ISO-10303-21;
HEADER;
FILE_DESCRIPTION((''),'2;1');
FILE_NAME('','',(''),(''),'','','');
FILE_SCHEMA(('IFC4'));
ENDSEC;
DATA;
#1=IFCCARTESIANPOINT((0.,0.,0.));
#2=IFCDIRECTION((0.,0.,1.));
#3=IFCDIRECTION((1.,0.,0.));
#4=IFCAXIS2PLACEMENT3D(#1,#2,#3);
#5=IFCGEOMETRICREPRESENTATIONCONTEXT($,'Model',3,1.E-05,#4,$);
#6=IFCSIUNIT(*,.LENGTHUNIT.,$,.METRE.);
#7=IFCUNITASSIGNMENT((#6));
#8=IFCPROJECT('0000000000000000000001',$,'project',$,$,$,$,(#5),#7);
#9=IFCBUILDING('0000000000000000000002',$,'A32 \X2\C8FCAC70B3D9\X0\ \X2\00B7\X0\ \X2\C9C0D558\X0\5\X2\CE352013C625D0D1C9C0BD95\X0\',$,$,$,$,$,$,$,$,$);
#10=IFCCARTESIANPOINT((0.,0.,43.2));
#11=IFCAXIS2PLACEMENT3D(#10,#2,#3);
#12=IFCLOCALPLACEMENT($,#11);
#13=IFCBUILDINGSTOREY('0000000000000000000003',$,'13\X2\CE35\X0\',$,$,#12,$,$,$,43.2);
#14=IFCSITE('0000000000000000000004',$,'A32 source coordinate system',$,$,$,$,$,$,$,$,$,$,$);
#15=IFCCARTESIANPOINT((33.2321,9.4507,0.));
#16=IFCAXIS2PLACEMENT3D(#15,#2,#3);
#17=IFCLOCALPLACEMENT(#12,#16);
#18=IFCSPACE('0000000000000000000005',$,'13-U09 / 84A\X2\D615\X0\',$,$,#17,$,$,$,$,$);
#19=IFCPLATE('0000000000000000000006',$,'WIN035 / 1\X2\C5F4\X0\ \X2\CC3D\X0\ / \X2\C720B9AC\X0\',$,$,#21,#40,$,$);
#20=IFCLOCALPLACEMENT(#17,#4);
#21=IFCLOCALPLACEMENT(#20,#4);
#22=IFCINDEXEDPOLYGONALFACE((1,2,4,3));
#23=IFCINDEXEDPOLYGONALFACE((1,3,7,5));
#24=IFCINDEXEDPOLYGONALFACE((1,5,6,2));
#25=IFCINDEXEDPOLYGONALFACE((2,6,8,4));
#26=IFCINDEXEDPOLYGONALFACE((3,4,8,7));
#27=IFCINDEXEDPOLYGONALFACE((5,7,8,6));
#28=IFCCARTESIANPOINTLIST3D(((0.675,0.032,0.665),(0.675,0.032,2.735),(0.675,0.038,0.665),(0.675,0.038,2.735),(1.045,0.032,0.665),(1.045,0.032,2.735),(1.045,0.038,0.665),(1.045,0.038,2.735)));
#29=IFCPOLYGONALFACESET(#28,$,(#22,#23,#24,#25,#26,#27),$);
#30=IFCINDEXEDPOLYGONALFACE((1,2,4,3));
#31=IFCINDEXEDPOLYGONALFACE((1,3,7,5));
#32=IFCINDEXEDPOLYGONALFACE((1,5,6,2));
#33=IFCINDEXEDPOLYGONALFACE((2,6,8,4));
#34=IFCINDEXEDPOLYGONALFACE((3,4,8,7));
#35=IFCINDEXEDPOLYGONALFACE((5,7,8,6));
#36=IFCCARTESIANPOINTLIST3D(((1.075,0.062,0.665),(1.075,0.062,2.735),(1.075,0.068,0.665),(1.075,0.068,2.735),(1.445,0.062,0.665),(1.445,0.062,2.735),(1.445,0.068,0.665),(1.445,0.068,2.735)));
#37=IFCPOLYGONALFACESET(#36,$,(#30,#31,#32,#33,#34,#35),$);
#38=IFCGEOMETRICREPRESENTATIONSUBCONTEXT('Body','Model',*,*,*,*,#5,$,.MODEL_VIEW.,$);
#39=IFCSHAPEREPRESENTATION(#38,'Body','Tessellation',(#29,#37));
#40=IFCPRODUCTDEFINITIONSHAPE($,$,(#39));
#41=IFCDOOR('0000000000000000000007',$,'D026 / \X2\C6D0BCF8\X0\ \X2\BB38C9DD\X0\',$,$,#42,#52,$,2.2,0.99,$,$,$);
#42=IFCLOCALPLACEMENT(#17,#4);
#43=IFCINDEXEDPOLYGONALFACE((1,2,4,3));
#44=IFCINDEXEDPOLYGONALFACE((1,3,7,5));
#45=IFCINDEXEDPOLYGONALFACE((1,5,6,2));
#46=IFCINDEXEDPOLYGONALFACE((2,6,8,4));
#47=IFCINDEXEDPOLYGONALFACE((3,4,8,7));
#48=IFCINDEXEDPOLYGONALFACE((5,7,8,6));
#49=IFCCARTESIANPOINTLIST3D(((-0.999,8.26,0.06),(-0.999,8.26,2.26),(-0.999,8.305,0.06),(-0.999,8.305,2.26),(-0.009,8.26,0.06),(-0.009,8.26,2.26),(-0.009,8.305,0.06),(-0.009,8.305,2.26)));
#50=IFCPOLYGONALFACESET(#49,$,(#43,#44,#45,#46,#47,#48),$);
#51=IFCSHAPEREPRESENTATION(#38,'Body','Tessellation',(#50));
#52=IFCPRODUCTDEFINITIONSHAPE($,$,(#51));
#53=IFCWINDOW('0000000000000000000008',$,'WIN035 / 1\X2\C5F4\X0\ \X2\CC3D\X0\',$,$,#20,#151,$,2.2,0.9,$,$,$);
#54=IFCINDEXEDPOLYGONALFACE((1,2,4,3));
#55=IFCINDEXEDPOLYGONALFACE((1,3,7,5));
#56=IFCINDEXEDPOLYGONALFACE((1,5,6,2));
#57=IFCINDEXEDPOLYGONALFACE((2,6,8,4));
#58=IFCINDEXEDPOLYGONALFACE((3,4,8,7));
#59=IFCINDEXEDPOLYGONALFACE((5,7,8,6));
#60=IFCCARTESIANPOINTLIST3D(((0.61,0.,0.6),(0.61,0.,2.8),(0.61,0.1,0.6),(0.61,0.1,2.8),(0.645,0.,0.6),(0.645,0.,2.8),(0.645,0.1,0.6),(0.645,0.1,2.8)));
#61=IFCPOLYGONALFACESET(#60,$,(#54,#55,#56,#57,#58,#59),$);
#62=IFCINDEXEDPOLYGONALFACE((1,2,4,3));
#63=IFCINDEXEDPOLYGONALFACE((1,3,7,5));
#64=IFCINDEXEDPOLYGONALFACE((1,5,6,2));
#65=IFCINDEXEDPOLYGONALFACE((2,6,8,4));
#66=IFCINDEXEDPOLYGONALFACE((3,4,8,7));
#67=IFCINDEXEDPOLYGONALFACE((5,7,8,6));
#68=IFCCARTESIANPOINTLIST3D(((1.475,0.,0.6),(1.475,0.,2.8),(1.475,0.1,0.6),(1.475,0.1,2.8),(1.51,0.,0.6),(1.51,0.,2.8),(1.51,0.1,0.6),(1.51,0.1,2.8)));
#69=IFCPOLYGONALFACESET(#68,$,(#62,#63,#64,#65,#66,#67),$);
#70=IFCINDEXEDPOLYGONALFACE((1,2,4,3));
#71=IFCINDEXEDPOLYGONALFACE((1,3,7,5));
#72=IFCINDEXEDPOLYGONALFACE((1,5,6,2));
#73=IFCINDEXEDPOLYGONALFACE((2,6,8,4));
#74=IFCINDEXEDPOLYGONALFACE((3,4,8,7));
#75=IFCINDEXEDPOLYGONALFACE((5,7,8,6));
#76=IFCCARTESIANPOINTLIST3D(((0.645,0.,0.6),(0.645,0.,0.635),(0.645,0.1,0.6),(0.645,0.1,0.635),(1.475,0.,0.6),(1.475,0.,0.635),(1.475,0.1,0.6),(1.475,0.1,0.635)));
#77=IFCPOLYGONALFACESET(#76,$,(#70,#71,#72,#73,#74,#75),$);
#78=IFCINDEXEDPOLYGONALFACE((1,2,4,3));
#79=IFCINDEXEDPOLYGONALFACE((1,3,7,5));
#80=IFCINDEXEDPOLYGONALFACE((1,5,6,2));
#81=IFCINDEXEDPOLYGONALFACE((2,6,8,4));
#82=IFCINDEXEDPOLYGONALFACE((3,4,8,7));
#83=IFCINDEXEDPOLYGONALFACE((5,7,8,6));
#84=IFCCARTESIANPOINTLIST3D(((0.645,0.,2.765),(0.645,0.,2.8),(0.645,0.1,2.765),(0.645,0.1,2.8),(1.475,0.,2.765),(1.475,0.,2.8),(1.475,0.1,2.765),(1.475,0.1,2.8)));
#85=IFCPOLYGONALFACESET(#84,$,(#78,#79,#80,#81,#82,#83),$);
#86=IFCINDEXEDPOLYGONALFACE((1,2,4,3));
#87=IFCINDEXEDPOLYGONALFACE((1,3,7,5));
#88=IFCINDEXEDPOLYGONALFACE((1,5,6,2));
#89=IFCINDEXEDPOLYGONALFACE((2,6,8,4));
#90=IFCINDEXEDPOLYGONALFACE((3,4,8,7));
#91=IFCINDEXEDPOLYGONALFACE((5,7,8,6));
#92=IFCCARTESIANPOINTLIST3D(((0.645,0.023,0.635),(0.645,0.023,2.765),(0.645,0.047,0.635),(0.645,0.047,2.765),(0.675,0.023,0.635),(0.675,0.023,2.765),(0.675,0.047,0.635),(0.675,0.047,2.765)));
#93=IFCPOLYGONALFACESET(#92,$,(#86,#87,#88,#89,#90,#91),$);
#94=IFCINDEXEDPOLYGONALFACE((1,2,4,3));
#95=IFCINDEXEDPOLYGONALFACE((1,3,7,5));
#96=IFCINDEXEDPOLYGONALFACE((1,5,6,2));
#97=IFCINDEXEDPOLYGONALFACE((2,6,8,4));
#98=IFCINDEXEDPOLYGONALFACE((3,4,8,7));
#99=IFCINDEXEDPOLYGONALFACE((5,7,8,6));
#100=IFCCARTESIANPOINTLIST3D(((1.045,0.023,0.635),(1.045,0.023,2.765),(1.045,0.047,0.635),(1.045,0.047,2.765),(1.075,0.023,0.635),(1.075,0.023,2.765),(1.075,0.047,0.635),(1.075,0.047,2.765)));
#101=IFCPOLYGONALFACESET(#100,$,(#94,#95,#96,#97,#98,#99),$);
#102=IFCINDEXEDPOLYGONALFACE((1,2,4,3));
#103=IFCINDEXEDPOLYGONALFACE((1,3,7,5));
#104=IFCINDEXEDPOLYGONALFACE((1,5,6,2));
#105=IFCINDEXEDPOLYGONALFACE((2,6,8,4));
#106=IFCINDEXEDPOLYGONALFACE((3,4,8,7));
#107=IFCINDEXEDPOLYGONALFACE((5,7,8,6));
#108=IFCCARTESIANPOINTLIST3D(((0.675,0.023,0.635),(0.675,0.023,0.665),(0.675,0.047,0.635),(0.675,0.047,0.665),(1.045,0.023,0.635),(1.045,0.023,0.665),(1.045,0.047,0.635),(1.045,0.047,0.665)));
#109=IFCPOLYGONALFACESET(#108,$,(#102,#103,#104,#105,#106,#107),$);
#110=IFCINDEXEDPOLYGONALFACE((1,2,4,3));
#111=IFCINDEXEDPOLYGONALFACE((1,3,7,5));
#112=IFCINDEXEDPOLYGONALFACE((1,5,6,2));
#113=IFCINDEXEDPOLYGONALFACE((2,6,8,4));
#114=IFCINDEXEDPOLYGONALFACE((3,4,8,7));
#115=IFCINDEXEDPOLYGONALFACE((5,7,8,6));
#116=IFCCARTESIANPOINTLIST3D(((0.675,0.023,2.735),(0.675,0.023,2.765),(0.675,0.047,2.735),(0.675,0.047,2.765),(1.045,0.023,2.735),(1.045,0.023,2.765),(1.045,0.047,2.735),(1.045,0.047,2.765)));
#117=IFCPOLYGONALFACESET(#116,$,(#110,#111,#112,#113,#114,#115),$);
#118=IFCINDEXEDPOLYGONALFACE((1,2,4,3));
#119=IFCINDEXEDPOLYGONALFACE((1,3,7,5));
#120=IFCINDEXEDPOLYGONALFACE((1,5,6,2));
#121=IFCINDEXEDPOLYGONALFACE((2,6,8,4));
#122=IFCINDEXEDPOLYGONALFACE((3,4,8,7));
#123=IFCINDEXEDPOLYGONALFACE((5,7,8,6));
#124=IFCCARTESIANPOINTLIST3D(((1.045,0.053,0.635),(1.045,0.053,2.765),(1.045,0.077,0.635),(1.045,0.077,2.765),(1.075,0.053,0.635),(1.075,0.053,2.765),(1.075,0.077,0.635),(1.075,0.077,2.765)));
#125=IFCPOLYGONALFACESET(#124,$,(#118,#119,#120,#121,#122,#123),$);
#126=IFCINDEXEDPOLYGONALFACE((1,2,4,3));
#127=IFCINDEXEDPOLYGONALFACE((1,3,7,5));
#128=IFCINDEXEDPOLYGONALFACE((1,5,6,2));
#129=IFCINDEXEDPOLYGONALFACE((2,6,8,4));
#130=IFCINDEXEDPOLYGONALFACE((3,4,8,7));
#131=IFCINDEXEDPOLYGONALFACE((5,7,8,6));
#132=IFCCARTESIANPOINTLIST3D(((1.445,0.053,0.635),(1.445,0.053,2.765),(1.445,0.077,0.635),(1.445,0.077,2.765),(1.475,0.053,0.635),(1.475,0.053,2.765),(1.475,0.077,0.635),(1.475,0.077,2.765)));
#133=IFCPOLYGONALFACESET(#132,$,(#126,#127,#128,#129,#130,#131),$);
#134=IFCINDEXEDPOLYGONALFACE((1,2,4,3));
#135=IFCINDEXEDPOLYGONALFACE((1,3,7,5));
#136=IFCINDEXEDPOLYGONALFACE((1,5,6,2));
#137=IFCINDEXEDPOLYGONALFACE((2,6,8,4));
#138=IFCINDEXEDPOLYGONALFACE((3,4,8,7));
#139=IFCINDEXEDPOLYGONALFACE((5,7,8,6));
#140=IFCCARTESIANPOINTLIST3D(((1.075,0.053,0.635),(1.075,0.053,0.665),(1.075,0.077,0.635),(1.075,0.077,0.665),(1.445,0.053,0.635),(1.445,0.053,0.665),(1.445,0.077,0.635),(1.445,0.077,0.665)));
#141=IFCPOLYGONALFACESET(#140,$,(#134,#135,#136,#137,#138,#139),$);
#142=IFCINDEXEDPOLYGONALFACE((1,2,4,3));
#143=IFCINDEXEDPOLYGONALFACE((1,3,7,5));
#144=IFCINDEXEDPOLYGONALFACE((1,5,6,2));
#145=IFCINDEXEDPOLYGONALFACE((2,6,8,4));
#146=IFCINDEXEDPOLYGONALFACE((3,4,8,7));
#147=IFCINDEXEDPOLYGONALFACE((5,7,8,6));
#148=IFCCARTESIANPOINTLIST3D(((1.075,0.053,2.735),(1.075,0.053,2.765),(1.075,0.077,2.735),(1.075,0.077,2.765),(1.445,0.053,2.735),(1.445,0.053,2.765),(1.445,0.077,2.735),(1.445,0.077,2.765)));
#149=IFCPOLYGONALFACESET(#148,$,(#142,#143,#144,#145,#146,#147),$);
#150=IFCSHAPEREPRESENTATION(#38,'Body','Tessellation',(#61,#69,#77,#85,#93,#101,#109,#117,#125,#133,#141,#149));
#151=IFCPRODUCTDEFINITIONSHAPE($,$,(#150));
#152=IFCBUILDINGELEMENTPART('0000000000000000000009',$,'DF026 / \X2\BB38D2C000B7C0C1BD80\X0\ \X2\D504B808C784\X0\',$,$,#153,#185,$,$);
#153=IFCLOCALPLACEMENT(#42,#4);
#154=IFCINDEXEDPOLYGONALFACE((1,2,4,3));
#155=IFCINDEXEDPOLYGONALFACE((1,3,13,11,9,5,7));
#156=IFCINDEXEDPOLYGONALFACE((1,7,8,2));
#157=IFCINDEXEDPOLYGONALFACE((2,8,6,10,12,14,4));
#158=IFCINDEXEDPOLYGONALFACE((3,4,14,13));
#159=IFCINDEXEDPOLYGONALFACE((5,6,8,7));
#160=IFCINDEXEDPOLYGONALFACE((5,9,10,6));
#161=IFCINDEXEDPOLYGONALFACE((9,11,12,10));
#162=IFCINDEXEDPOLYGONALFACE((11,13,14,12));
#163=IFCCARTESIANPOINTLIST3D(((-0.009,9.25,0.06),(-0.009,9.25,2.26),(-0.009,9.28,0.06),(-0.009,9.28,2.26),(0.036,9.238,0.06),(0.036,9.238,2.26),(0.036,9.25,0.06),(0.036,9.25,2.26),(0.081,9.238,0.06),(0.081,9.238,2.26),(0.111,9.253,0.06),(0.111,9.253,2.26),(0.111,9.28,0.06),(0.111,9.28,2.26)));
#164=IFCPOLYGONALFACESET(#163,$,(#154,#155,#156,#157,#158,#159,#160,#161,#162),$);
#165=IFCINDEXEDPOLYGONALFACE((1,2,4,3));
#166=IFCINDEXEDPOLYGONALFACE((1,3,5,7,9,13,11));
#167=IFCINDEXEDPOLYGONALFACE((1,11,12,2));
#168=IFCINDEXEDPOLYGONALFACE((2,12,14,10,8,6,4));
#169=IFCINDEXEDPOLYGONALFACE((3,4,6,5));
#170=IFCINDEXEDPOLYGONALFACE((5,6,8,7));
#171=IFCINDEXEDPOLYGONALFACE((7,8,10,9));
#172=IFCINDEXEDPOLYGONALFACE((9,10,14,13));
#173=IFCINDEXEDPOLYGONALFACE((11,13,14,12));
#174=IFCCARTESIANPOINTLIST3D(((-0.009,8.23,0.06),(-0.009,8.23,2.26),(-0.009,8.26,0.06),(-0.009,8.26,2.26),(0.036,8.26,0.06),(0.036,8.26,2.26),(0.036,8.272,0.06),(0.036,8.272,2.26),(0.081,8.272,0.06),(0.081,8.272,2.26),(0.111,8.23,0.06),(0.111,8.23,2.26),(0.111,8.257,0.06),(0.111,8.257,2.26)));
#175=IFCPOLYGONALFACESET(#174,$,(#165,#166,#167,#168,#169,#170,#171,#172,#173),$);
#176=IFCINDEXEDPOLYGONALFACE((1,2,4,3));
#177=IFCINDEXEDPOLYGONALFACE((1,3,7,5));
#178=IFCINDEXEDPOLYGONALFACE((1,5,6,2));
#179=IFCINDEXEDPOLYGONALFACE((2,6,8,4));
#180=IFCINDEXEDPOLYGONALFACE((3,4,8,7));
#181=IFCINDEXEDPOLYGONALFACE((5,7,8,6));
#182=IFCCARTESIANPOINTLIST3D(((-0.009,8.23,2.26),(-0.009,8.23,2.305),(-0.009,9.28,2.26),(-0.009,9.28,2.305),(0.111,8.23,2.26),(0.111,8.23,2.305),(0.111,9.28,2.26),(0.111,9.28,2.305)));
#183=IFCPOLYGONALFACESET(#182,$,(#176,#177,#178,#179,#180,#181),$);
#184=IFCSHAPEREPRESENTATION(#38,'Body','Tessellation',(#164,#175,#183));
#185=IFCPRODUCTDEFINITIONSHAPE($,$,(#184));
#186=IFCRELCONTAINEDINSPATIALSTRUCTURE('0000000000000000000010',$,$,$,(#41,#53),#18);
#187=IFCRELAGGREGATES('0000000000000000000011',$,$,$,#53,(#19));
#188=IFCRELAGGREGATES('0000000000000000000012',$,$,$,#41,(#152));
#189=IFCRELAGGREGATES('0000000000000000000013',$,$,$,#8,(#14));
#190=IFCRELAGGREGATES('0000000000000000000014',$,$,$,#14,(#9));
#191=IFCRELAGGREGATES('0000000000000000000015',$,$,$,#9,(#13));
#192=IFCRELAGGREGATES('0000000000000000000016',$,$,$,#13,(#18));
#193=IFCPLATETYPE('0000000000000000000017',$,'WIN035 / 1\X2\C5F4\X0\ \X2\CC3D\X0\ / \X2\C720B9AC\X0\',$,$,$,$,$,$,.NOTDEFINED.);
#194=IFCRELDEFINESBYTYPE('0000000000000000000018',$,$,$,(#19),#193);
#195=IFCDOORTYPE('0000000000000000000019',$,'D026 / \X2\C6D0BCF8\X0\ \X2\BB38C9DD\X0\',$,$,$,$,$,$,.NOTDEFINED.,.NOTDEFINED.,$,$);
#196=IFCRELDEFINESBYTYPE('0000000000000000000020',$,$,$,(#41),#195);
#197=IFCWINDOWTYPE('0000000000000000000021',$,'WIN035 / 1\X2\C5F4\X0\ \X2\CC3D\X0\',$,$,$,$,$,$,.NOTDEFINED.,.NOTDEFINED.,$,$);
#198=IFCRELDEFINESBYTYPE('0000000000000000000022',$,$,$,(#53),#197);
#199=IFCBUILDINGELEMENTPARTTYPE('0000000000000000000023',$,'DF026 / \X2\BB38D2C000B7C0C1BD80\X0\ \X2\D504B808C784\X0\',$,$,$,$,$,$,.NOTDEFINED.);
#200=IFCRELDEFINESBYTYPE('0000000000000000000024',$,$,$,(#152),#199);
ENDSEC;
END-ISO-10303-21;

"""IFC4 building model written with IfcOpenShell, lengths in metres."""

from ifc_helpers import new_model, si_unit, frame, origin, origin_with_axes, place, context, subcontext, project, spatial, polyline, outline, extrude, source, transform, mapped, type_object, type_shapes, element, aggregate, save


model = new_model("IFC4")

# Units and contexts
model_context = context("Model", 3, precision=1e-05, world=origin_with_axes())
body_context = subcontext(model_context, "Body", "Model", "MODEL_VIEW")
ifc_project = project(units=[si_unit("LENGTHUNIT", "METRE")], contexts=[model_context])

# Plate
plate_type_1 = type_object("IfcPlateType", Name="WIN035 / 1열 창 / 유리", PredefinedType="NOTDEFINED")
shared_shape_1 = source(origin(), body_context, "Body", "SweptSolid", [
    extrude(outline(polyline([(0.675, 0.032), (0.675, 0.038), (1.045, 0.038), (1.045, 0.032), (0.675, 0.032)])), frame((0.0, 0.0, 0.665)), (0.0, 0.0, 1.0), 2.07),
    extrude(outline(polyline([(1.075, 0.062), (1.075, 0.068), (1.445, 0.068), (1.445, 0.062), (1.075, 0.062)])), frame((0.0, 0.0, 0.665)), (0.0, 0.0, 1.0), 2.07),
])
type_shapes(plate_type_1, [shared_shape_1])
storey_placement = place(None, frame((0.0, 0.0, 43.2), z_axis=(0.0, 0.0, 1.0), x_axis=(1.0, 0.0, 0.0)))
space_placement = place(storey_placement, frame((33.2321, 9.4507, 0.0), z_axis=(0.0, 0.0, 1.0), x_axis=(1.0, 0.0, 0.0)))
window_1_placement = place(space_placement, origin_with_axes())
plate_1_placement = place(window_1_placement, origin_with_axes())
plate_1 = element("IfcPlate", 1, at=plate_1_placement, type_object=plate_type_1, Name="WIN035 / 1열 창 / 유리", context=body_context, shape_type="MappedRepresentation", body=[
    mapped(shared_shape_1, transform((0.0, 0.0, 0.0), scale=1.0)),
])

# Site, building, storey, space
site = spatial("IfcSite", under=ifc_project, Name="A32 source coordinate system")
building = spatial("IfcBuilding", under=site, Name="A32 주거동 · 지하5층–옥탑지붕")
storey = spatial("IfcBuildingStorey", under=building, at=storey_placement, Name="13층", Elevation=43.2)
space = spatial("IfcSpace", under=storey, at=space_placement, Name="13-U09 / 84A형")

# Door
door_type_1 = type_object("IfcDoorType", Name="D026 / 원본 문짝", OperationType="NOTDEFINED", PredefinedType="NOTDEFINED")
shared_shape_2 = source(origin(), body_context, "Body", "SweptSolid", [
    extrude(outline(polyline([(-0.009, 8.26), (-0.999, 8.26), (-0.999, 8.305), (-0.009, 8.305), (-0.009, 8.26)])), frame((0.0, 0.0, 0.06)), (0.0, 0.0, 1.0), 2.2),
])
type_shapes(door_type_1, [shared_shape_2])
door_1_placement = place(space_placement, origin_with_axes())
door_1 = element("IfcDoor", 2, at=door_1_placement, inside=space, type_object=door_type_1, Name="D026 / 원본 문짝", OverallHeight=2.2, OverallWidth=0.99, context=body_context, shape_type="MappedRepresentation", body=[
    mapped(shared_shape_2, transform((0.0, 0.0, 0.0), scale=1.0)),
])

# Window
window_type_1 = type_object("IfcWindowType", Name="WIN035 / 1열 창", PartitioningType="NOTDEFINED", PredefinedType="NOTDEFINED")
shared_shape_3 = source(origin(), body_context, "Body", "SweptSolid", [
    extrude(outline(polyline([(0.61, 0.0), (0.61, 0.1), (0.645, 0.1), (0.645, 0.0), (0.61, 0.0)])), frame((0.0, 0.0, 0.6)), (0.0, 0.0, 1.0), 2.2),
    extrude(outline(polyline([(1.475, 0.0), (1.475, 0.1), (1.51, 0.1), (1.51, 0.0), (1.475, 0.0)])), frame((0.0, 0.0, 0.6)), (0.0, 0.0, 1.0), 2.2),
    extrude(outline(polyline([(0.645, 0.0), (0.645, 0.1), (1.475, 0.1), (1.475, 0.0), (0.645, 0.0)])), frame((0.0, 0.0, 0.6)), (0.0, 0.0, 1.0), 0.035),
    extrude(outline(polyline([(0.645, 0.0), (0.645, 0.1), (1.475, 0.1), (1.475, 0.0), (0.645, 0.0)])), frame((0.0, 0.0, 2.765)), (0.0, 0.0, 1.0), 0.035),
    extrude(outline(polyline([(0.645, 0.023), (0.645, 0.047), (0.675, 0.047), (0.675, 0.023), (0.645, 0.023)])), frame((0.0, 0.0, 0.635)), (0.0, 0.0, 1.0), 2.13),
    extrude(outline(polyline([(1.045, 0.023), (1.045, 0.047), (1.075, 0.047), (1.075, 0.023), (1.045, 0.023)])), frame((0.0, 0.0, 0.635)), (0.0, 0.0, 1.0), 2.13),
    extrude(outline(polyline([(0.675, 0.023), (0.675, 0.047), (1.045, 0.047), (1.045, 0.023), (0.675, 0.023)])), frame((0.0, 0.0, 0.635)), (0.0, 0.0, 1.0), 0.03),
    extrude(outline(polyline([(0.675, 0.023), (0.675, 0.047), (1.045, 0.047), (1.045, 0.023), (0.675, 0.023)])), frame((0.0, 0.0, 2.735)), (0.0, 0.0, 1.0), 0.03),
    extrude(outline(polyline([(1.045, 0.053), (1.045, 0.077), (1.075, 0.077), (1.075, 0.053), (1.045, 0.053)])), frame((0.0, 0.0, 0.635)), (0.0, 0.0, 1.0), 2.13),
    extrude(outline(polyline([(1.445, 0.053), (1.445, 0.077), (1.475, 0.077), (1.475, 0.053), (1.445, 0.053)])), frame((0.0, 0.0, 0.635)), (0.0, 0.0, 1.0), 2.13),
    extrude(outline(polyline([(1.075, 0.053), (1.075, 0.077), (1.445, 0.077), (1.445, 0.053), (1.075, 0.053)])), frame((0.0, 0.0, 0.635)), (0.0, 0.0, 1.0), 0.03),
    extrude(outline(polyline([(1.075, 0.053), (1.075, 0.077), (1.445, 0.077), (1.445, 0.053), (1.075, 0.053)])), frame((0.0, 0.0, 2.735)), (0.0, 0.0, 1.0), 0.03),
])
type_shapes(window_type_1, [shared_shape_3])
window_1 = element("IfcWindow", 3, at=window_1_placement, inside=space, type_object=window_type_1, Name="WIN035 / 1열 창", OverallHeight=2.2, OverallWidth=0.9, context=body_context, shape_type="MappedRepresentation", body=[
    mapped(shared_shape_3, transform((0.0, 0.0, 0.0), scale=1.0)),
])
aggregate(window_1, [plate_1])

# Building element part
building_element_part_type_1 = type_object("IfcBuildingElementPartType", Name="DF026 / 문틀·상부 프레임", PredefinedType="NOTDEFINED")
shared_shape_4 = source(origin(), body_context, "Body", "SweptSolid", [
    extrude(outline(polyline([(0.111, 9.28), (0.111, 9.253), (0.081, 9.238), (0.036, 9.238), (0.036, 9.25), (-0.009, 9.25), (-0.009, 9.28), (0.111, 9.28)])), frame((0.0, 0.0, 0.06)), (0.0, 0.0, 1.0), 2.2),
    extrude(outline(polyline([(-0.009, 8.26), (0.036, 8.26), (0.036, 8.272), (0.081, 8.272), (0.111, 8.257), (0.111, 8.23), (-0.009, 8.23), (-0.009, 8.26)])), frame((0.0, 0.0, 0.06)), (0.0, 0.0, 1.0), 2.2),
    extrude(outline(polyline([(-0.009, 8.23), (-0.009, 9.28), (0.111, 9.28), (0.111, 8.23), (-0.009, 8.23)])), frame((0.0, 0.0, 2.26)), (0.0, 0.0, 1.0), 0.045),
])
type_shapes(building_element_part_type_1, [shared_shape_4])
building_element_part_1_placement = place(door_1_placement, origin_with_axes())
building_element_part_1 = element("IfcBuildingElementPart", 4, at=building_element_part_1_placement, type_object=building_element_part_type_1, Name="DF026 / 문틀·상부 프레임", context=body_context, shape_type="MappedRepresentation", body=[
    mapped(shared_shape_4, transform((0.0, 0.0, 0.0), scale=1.0)),
])
aggregate(door_1, [building_element_part_1])

save(model, "model.ifc")
